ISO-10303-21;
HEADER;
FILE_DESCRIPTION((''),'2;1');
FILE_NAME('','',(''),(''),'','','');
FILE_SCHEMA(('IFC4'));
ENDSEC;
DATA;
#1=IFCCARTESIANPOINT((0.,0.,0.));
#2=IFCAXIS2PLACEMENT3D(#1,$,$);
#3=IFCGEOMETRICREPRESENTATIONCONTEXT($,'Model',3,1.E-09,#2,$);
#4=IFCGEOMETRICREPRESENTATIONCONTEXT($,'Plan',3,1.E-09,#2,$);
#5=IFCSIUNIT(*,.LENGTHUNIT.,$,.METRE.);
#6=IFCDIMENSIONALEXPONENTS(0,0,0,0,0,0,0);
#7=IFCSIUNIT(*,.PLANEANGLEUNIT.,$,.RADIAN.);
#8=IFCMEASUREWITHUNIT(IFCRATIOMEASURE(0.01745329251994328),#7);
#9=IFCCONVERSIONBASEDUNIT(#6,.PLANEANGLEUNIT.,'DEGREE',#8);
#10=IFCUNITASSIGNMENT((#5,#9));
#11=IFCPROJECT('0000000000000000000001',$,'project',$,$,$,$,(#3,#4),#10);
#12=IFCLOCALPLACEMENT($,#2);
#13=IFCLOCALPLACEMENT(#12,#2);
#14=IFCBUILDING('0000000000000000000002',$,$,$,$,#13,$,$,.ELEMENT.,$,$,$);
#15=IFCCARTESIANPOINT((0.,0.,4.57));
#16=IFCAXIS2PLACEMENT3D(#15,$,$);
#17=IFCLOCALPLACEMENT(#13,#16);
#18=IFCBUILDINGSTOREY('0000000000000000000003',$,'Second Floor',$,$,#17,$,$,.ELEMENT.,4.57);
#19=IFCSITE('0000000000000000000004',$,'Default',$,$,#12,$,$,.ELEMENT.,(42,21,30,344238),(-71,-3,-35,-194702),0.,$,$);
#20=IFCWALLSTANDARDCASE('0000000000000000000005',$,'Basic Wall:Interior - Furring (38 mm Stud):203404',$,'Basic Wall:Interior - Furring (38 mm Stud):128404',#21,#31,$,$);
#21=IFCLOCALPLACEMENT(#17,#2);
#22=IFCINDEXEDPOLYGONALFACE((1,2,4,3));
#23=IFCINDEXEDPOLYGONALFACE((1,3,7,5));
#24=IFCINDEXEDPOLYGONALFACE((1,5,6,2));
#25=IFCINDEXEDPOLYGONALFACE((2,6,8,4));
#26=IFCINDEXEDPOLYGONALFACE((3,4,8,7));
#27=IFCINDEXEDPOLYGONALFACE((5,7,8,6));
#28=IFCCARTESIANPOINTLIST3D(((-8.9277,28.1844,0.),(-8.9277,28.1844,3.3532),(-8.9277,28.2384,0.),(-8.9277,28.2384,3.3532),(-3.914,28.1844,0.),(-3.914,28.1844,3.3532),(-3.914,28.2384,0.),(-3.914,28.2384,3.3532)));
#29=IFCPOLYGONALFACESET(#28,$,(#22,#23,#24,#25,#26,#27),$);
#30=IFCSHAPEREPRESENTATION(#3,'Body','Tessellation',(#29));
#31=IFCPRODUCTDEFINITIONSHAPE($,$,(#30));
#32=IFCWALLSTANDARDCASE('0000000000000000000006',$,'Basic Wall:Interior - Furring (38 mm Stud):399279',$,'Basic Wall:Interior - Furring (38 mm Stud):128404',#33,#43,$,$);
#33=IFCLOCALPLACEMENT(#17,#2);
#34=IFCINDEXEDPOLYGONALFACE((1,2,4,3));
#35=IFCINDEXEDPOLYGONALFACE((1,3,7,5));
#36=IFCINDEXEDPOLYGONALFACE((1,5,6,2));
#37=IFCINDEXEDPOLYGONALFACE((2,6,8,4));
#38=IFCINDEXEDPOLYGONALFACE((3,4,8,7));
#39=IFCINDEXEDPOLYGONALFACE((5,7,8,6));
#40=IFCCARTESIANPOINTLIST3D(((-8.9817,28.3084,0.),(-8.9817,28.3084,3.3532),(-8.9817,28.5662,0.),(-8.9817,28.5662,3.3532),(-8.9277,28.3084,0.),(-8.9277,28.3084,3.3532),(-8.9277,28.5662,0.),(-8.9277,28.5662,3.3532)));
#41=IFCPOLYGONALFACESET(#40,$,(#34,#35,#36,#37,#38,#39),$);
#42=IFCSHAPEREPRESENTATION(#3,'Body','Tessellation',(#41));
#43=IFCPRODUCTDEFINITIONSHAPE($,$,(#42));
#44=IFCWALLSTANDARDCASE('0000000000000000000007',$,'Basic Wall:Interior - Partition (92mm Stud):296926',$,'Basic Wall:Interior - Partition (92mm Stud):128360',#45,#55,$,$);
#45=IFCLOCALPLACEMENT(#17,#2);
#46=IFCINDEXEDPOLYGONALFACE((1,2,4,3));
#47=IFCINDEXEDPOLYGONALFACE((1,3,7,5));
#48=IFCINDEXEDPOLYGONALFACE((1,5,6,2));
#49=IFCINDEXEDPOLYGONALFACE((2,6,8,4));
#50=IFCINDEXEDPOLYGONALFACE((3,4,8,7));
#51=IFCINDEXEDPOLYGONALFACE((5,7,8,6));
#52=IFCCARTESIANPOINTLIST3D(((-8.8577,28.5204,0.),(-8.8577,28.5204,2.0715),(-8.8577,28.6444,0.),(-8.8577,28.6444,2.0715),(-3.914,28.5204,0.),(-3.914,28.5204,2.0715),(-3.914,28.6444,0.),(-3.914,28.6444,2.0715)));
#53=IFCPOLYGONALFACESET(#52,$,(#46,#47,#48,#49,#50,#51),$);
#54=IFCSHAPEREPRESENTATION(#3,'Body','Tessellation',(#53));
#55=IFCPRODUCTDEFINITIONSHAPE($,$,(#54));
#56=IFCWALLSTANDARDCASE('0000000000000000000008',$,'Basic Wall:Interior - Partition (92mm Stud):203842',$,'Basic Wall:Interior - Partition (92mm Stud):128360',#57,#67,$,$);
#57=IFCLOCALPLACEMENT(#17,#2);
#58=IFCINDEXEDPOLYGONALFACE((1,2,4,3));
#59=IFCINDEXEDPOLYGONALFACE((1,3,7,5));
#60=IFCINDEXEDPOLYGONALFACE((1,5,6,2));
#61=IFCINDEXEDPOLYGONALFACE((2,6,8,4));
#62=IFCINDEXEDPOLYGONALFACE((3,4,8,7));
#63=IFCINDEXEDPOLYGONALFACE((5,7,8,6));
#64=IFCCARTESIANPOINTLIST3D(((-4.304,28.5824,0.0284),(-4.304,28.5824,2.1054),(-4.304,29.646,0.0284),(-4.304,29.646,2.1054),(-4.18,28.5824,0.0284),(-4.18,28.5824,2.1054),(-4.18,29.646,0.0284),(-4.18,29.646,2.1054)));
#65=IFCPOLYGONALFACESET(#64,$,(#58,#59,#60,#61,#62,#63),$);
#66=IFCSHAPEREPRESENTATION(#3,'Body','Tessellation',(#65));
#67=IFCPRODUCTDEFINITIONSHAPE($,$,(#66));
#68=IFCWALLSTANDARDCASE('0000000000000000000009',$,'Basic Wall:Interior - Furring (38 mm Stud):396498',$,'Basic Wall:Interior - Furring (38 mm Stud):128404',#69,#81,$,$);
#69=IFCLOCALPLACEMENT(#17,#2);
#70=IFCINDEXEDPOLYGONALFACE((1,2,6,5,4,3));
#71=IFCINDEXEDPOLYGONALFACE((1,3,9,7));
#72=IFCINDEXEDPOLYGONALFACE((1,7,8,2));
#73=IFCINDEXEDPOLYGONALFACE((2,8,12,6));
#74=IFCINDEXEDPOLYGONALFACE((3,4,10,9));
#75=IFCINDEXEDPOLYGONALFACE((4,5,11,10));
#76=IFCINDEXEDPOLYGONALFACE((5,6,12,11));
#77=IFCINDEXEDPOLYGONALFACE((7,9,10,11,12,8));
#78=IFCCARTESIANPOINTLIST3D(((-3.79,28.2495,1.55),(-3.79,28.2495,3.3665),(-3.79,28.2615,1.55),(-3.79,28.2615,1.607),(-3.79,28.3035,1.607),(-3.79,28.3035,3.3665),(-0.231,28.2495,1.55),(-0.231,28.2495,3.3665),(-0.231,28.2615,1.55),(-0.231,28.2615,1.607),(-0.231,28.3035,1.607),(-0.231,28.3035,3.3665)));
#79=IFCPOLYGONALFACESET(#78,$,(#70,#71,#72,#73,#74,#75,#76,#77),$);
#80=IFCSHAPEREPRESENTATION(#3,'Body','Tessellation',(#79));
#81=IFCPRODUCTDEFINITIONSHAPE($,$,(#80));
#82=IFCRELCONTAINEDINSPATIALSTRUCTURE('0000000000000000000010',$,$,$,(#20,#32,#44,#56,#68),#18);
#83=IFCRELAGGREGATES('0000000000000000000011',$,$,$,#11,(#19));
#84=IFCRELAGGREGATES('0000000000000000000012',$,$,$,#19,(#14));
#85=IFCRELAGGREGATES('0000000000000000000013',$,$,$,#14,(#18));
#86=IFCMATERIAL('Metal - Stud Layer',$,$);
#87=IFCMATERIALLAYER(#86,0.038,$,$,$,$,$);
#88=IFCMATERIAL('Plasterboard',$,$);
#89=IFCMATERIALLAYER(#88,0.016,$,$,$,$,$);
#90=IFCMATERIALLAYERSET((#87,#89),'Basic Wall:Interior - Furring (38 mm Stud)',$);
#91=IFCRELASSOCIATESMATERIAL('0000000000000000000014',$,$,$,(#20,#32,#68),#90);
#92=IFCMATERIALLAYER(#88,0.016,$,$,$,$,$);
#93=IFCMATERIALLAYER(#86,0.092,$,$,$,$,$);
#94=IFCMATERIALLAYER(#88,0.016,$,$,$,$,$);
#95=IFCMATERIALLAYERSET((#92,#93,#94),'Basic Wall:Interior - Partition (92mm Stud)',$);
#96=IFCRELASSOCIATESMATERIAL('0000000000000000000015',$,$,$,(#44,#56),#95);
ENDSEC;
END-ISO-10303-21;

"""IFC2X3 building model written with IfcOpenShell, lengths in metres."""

from ifc_helpers import new_model, entity, si_unit, converted_unit, frame, frame_2d, origin, place, context, project, spatial, polyline, rectangle, extrude, clip, bounded_halfspace, material, layer, layer_set, layer_usage, element, save


model = new_model("IFC2X3")

# Units and contexts
model_context = context("Model", 3, precision=1e-09, world=origin())
plan_context = context("Plan", 3, precision=1e-09, world=origin())
ifc_project = project(units=[si_unit("LENGTHUNIT", "METRE"), converted_unit("PLANEANGLEUNIT", "DEGREE", entity("IfcRatioMeasure", 0.01745329251994328), si_unit("PLANEANGLEUNIT", "RADIAN"), dimensions=[0, 0, 0, 0, 0, 0, 0])], contexts=[model_context, plan_context])

# Site, building, storey
site_placement = place(None, origin())
site = spatial("IfcSite", under=ifc_project, at=site_placement, Name="Default", CompositionType="ELEMENT", RefLatitude=(42, 21, 30, 344238), RefLongitude=(-71, -3, -35, -194702), RefElevation=0.0)
building_placement = place(site_placement, origin())
building = spatial("IfcBuilding", under=site, at=building_placement, CompositionType="ELEMENT")
storey_placement = place(building_placement, frame((0.0, 0.0, 4.57)))
storey = spatial("IfcBuildingStorey", under=building, at=storey_placement, Name="Second Floor", CompositionType="ELEMENT", Elevation=4.57)

# Shared definitions
ifc_material_1 = material(Name="Plasterboard")
ifc_layer_1 = layer(ifc_material_1, 0.016)
ifc_material_2 = material(Name="Metal - Stud Layer")
ifc_layer_2 = layer(ifc_material_2, 0.092)
ifc_layer_3 = layer(ifc_material_1, 0.016)
ifc_layer_set_1 = layer_set([ifc_layer_1, ifc_layer_2, ifc_layer_3], Name="Basic Wall:Interior - Partition (92mm Stud)")
ifc_layer_usage_1 = layer_usage(ifc_layer_set_1, "AXIS2", "NEGATIVE", 0.062)

# Walls
ifc_layer_4 = layer(ifc_material_2, 0.038)
ifc_layer_5 = layer(ifc_material_1, 0.016)
ifc_layer_set_2 = layer_set([ifc_layer_4, ifc_layer_5], Name="Basic Wall:Interior - Furring (38 mm Stud)")
ifc_layer_usage_2 = layer_usage(ifc_layer_set_2, "AXIS2", "POSITIVE", -0.027)
wall_1_placement = place(storey_placement, frame((-3.914, 28.2114, 0.0), z_axis=(0.0, 0.0, 1.0), x_axis=(-1.0, 0.0, 0.0)))
element("IfcWallStandardCase", 1, at=wall_1_placement, inside=storey, material=ifc_layer_usage_2, Name="Basic Wall:Interior - Furring (38 mm Stud):203404", ObjectType="Basic Wall:Interior - Furring (38 mm Stud):128404", context=model_context, shape_type="SweptSolid", body=[
    extrude(rectangle(XDim=5.0138, YDim=0.054, at=frame_2d((2.5069, 0.0), x_axis=(-1.0, 0.0))), origin(), (0.0, 0.0, 1.0), 3.3532),
])
ifc_layer_usage_3 = layer_usage(ifc_layer_set_2, "AXIS2", "NEGATIVE", 0.027)
wall_2_placement = place(storey_placement, frame((-8.9547, 28.5662, 0.0), z_axis=(0.0, 0.0, 1.0), x_axis=(0.0, -1.0, 0.0)))
element("IfcWallStandardCase", 2, at=wall_2_placement, inside=storey, material=ifc_layer_usage_3, Name="Basic Wall:Interior - Furring (38 mm Stud):399279", ObjectType="Basic Wall:Interior - Furring (38 mm Stud):128404", context=model_context, shape_type="SweptSolid", body=[
    extrude(rectangle(XDim=0.2578, YDim=0.054, at=frame_2d((0.1289, 0.0), x_axis=(-1.0, 0.0))), origin(), (0.0, 0.0, 1.0), 3.3532),
])

# Walls
wall_3_placement = place(storey_placement, frame((-8.8577, 28.5824, 0.0)))
element("IfcWallStandardCase", 3, at=wall_3_placement, inside=storey, material=ifc_layer_usage_1, Name="Basic Wall:Interior - Partition (92mm Stud):296926", ObjectType="Basic Wall:Interior - Partition (92mm Stud):128360", context=model_context, shape_type="SweptSolid", body=[
    extrude(rectangle(XDim=4.9438, YDim=0.124, at=frame_2d((2.4719, 0.0), x_axis=(-1.0, 0.0))), origin(), (0.0, 0.0, 1.0), 2.0715),
])
wall_4_placement = place(storey_placement, frame((-4.242, 29.646, 0.0284), z_axis=(0.0, 0.0, 1.0), x_axis=(0.0, -1.0, 0.0)))
element("IfcWallStandardCase", 4, at=wall_4_placement, inside=storey, material=ifc_layer_usage_1, Name="Basic Wall:Interior - Partition (92mm Stud):203842", ObjectType="Basic Wall:Interior - Partition (92mm Stud):128360", context=model_context, shape_type="SweptSolid", body=[
    extrude(rectangle(XDim=1.0636, YDim=0.124, at=frame_2d((0.5318, 0.0), x_axis=(-1.0, 0.0))), origin(), (0.0, 0.0, 1.0), 2.077),
])
wall_5_placement = place(storey_placement, frame((-3.79, 28.2765, 1.55)))
element("IfcWallStandardCase", 5, at=wall_5_placement, inside=storey, material=ifc_layer_usage_3, Name="Basic Wall:Interior - Furring (38 mm Stud):396498", ObjectType="Basic Wall:Interior - Furring (38 mm Stud):128404", context=model_context, shape_type="Clipping", body=[
    clip(clip(extrude(rectangle(XDim=3.559, YDim=0.054, at=frame_2d((1.7795, 0.0), x_axis=(-1.0, 0.0))), origin(), (0.0, 0.0, 1.0), 1.8165), bounded_halfspace(frame((3.559, -0.015, 0.057), z_axis=(0.0, 0.0, 1.0), x_axis=(0.0, -1.0, 0.0)), True, frame((3.559, -0.015, 0.057), z_axis=(0.0, 0.0, 1.0), x_axis=(0.0, -1.0, 0.0)), polyline([(0.0, 0.0), (-0.042, 0.0), (-0.042, -3.559), (0.0, -3.559), (0.0, 0.0)]))), bounded_halfspace(frame((0.0, -0.015, 0.057), z_axis=(0.0, -1.0, 0.0), x_axis=(0.0, 0.0, -1.0)), True, frame((0.0, -0.015, 0.057), z_axis=(0.0, -1.0, 0.0), x_axis=(0.0, 0.0, -1.0)), polyline([(0.0, 0.0), (0.057, 0.0), (0.057, 3.559), (0.0, 3.559), (0.0, 0.0)]))),
])

save(model, "model.ifc")
